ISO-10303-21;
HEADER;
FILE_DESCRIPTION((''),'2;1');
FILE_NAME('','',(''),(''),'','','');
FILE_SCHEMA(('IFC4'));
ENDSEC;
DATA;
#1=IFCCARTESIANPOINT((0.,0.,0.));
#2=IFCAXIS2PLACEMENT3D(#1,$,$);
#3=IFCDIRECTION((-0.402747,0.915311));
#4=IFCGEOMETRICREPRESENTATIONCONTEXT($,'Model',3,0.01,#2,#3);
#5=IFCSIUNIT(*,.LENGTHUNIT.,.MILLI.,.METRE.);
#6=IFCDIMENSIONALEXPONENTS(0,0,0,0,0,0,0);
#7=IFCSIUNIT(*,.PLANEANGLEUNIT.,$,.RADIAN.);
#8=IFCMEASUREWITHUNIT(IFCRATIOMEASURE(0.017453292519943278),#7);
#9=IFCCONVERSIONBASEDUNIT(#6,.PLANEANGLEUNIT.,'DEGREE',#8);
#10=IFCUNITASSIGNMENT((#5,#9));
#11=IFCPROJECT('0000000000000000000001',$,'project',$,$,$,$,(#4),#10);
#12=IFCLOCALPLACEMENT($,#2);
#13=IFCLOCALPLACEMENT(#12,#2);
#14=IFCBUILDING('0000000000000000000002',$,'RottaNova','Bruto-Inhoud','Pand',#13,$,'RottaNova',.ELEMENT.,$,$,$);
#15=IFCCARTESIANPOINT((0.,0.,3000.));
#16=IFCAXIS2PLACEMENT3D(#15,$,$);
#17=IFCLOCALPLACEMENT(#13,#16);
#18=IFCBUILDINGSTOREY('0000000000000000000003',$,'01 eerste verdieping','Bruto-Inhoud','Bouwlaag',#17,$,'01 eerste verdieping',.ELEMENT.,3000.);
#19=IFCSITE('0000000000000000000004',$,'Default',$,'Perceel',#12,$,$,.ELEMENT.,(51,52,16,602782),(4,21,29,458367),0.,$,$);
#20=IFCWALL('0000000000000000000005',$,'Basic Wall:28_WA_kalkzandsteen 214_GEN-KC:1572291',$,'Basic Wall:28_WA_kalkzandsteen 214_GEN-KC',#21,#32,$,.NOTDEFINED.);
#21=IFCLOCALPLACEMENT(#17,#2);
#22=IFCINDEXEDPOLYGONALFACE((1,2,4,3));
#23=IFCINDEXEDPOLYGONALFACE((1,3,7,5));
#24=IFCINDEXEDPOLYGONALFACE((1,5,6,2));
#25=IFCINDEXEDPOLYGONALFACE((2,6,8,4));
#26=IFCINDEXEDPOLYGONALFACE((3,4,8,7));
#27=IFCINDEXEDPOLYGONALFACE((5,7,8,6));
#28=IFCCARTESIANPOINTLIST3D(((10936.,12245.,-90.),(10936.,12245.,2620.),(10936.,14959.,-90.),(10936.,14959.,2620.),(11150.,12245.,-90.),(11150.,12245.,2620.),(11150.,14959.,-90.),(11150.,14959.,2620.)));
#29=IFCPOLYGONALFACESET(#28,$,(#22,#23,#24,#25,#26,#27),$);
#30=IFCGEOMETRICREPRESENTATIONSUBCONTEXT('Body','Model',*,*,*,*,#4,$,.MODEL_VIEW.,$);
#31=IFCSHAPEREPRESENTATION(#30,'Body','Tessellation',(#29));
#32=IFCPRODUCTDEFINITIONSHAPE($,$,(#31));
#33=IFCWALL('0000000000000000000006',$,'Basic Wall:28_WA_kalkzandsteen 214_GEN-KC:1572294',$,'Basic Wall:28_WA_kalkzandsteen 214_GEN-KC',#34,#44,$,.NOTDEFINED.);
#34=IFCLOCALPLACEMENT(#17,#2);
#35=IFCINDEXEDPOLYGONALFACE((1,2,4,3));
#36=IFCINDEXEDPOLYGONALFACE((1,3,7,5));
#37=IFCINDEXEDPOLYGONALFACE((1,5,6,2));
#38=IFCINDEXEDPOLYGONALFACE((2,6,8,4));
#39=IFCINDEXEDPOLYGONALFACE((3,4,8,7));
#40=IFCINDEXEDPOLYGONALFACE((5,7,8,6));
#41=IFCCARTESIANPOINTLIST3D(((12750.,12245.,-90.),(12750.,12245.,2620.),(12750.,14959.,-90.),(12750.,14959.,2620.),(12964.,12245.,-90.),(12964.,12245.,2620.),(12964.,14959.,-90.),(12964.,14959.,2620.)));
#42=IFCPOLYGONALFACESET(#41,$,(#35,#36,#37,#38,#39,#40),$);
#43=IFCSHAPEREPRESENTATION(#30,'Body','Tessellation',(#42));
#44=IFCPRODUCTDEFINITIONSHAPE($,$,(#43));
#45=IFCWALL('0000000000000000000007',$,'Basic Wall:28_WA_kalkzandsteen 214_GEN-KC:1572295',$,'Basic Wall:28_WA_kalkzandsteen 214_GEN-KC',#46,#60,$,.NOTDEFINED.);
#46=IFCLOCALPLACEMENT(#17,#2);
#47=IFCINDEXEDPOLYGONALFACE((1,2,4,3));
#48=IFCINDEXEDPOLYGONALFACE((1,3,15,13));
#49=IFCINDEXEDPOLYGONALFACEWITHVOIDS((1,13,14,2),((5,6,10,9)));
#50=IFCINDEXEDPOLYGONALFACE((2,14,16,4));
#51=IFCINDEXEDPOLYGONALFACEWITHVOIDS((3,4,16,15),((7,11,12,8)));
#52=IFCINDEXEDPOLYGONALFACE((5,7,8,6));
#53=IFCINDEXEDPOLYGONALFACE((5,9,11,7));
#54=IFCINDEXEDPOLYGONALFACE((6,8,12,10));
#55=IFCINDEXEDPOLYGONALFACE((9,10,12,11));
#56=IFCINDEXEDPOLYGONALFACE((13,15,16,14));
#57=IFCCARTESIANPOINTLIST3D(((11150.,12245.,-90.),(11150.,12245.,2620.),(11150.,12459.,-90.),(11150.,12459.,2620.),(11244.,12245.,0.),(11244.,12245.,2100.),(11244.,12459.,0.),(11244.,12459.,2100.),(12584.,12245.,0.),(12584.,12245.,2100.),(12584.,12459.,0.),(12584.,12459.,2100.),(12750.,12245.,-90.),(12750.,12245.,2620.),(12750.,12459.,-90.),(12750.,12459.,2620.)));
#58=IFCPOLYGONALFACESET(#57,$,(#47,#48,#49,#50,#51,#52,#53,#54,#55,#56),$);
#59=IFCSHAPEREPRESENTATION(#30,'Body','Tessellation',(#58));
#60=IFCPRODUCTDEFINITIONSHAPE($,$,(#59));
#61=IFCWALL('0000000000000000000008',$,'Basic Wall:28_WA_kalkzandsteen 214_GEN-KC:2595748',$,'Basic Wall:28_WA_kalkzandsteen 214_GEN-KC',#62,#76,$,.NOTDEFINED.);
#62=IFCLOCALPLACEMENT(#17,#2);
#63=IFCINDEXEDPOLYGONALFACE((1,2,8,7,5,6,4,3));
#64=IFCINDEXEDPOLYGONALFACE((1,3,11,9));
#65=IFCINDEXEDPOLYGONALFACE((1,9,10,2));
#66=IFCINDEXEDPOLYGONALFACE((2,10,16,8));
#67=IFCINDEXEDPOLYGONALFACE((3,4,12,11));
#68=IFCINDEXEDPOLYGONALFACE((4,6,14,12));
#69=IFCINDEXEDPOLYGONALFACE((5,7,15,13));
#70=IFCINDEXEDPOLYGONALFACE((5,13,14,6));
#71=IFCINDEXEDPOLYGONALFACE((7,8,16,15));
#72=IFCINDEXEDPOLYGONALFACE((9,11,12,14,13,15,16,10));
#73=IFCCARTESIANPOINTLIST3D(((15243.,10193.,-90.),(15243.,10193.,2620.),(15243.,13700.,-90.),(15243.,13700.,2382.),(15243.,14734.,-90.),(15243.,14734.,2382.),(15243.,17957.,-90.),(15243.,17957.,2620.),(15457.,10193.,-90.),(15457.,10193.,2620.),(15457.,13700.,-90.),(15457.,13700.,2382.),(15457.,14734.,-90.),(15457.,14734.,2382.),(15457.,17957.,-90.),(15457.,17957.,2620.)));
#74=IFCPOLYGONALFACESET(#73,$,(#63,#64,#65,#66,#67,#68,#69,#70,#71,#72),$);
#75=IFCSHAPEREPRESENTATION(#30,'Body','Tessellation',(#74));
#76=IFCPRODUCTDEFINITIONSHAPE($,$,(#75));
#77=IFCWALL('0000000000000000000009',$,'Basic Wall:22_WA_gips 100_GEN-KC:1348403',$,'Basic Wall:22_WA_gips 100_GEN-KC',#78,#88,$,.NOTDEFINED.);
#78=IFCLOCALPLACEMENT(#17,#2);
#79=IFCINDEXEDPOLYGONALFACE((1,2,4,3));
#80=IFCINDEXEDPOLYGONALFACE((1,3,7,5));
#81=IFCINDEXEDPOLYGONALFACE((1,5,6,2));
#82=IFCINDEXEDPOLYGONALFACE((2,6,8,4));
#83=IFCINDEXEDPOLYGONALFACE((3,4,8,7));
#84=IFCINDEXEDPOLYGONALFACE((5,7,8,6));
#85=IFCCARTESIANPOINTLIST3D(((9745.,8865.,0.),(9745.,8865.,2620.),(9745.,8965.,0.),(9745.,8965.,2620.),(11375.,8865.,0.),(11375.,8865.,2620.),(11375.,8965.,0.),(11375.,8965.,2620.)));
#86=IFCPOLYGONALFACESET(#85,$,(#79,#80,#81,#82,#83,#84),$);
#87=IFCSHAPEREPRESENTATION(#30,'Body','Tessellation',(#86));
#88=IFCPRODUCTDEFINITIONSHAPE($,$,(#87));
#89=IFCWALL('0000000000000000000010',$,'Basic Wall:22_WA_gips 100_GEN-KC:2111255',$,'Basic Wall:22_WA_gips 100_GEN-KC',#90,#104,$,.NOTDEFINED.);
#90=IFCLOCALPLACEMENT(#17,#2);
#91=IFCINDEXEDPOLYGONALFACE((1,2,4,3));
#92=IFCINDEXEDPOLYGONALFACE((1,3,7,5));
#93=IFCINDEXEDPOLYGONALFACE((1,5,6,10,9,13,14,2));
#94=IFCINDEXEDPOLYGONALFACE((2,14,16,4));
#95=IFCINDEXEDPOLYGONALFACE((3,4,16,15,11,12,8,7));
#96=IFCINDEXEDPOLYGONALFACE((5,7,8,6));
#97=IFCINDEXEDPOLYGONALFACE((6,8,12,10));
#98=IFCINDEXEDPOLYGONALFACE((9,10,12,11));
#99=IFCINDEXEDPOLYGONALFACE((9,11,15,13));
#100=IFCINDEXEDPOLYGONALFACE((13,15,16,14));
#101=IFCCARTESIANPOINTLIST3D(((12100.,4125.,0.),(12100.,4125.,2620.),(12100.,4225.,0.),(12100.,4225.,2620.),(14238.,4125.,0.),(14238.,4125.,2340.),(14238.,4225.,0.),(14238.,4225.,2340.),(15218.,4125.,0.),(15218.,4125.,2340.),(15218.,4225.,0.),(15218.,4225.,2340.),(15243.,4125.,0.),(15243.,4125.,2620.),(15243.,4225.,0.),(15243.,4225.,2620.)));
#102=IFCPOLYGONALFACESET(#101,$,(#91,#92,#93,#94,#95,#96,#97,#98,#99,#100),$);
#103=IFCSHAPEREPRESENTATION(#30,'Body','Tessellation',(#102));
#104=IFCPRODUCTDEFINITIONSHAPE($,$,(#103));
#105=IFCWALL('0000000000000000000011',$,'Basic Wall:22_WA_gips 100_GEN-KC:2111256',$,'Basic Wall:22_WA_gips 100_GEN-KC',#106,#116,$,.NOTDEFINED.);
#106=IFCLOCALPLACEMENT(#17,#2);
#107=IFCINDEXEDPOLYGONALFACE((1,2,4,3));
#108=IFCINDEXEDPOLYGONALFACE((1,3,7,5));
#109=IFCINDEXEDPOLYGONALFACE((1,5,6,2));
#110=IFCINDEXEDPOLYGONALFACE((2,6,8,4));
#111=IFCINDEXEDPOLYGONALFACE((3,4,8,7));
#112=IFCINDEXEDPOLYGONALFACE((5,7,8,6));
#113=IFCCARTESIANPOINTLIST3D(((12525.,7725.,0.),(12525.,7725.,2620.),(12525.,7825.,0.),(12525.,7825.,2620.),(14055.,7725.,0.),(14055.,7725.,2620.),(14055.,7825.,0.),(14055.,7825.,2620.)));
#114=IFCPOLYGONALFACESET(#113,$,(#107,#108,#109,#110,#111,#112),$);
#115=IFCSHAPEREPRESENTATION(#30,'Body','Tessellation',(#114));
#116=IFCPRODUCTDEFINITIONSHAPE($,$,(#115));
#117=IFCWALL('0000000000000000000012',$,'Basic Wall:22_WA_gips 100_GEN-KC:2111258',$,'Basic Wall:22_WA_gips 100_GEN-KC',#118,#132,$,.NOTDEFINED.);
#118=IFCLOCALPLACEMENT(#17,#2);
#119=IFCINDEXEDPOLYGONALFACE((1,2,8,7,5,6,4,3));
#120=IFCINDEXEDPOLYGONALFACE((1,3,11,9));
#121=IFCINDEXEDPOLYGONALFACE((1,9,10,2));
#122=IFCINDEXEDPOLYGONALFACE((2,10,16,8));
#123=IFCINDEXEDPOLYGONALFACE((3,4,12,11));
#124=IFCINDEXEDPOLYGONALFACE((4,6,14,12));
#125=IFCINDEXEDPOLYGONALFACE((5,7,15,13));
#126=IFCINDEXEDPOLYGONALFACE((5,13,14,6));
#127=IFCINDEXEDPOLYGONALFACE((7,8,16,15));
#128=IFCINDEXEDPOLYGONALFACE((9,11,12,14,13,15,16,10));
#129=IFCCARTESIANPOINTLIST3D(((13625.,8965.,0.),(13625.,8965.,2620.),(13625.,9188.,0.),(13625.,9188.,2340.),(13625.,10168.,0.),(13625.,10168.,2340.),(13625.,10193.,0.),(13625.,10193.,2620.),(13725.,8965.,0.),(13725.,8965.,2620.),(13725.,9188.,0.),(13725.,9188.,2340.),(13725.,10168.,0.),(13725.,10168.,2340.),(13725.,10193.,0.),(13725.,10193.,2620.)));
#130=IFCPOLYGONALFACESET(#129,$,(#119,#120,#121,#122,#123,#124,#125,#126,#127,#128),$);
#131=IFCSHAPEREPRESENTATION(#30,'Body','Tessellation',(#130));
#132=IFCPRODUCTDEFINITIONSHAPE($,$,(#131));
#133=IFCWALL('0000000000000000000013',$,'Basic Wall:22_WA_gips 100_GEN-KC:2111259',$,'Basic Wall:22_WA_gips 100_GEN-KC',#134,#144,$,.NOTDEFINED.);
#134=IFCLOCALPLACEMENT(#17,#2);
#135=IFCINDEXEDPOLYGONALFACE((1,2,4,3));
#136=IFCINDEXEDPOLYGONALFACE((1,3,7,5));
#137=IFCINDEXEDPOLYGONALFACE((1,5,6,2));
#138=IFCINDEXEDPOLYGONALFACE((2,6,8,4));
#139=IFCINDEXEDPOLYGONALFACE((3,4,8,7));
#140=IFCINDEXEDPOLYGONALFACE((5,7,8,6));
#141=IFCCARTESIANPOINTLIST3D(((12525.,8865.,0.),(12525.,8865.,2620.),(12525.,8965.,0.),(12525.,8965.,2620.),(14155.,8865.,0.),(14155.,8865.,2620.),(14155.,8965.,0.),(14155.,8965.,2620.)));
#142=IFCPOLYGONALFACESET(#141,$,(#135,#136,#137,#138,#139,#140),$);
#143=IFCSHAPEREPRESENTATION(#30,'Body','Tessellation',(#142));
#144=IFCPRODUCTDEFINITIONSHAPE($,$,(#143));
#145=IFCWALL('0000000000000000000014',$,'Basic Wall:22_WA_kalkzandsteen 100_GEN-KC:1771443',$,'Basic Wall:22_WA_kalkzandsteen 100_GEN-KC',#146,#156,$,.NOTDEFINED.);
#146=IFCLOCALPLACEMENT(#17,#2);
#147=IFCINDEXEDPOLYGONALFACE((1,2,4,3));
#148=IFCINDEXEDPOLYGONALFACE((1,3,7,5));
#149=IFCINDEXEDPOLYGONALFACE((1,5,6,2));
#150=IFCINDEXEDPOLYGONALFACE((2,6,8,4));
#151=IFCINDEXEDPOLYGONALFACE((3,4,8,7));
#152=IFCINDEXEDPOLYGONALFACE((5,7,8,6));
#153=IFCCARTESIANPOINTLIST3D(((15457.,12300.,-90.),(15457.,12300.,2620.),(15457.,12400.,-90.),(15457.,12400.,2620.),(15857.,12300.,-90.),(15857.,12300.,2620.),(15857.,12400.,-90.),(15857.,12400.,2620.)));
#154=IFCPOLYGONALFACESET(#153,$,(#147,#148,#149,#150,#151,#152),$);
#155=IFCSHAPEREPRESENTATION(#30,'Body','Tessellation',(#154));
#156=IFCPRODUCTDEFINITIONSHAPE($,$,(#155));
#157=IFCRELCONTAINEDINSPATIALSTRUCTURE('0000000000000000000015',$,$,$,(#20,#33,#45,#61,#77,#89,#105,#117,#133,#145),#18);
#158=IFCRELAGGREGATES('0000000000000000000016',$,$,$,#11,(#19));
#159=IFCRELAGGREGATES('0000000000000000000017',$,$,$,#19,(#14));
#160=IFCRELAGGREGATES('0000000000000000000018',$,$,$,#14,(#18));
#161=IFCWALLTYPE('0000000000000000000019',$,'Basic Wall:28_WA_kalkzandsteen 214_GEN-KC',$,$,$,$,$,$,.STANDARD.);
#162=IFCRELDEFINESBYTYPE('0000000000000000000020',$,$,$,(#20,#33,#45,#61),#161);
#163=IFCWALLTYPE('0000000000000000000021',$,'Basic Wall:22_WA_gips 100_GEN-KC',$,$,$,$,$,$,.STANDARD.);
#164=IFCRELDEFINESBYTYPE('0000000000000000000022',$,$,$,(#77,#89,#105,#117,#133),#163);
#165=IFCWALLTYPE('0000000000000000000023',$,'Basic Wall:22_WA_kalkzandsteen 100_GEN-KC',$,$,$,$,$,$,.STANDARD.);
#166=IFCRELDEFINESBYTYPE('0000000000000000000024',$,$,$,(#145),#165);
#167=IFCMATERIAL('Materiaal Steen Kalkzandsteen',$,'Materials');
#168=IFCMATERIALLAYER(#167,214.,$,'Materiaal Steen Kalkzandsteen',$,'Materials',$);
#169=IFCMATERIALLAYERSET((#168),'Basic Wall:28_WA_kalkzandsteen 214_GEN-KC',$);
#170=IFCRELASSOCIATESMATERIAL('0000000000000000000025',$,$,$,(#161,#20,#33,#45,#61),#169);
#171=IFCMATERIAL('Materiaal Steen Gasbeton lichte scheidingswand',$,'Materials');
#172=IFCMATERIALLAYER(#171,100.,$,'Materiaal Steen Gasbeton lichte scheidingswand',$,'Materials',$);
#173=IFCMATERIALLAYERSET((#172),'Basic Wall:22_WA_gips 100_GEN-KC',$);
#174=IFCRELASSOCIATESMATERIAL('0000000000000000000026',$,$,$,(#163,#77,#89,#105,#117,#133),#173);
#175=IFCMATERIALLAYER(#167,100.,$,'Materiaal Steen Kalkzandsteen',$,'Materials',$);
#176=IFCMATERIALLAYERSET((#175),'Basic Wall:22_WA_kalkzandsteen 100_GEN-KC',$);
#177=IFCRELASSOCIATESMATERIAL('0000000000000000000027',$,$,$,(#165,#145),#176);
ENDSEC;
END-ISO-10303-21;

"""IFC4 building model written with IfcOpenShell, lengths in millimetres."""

from ifc_helpers import new_model, entity, si_unit, converted_unit, direction, frame, frame_2d, origin, place, context, subcontext, project, spatial, rectangle, extrude, material, layer, layer_set, type_object, element, save


model = new_model("IFC4")

# Units and contexts
model_context = context("Model", 3, precision=0.01, world=origin(), true_north=direction((-0.402747, 0.915311)))
body_context = subcontext(model_context, "Body", "Model", "MODEL_VIEW")
ifc_project = project(units=[si_unit("LENGTHUNIT", "METRE", prefix="MILLI"), converted_unit("PLANEANGLEUNIT", "DEGREE", entity("IfcRatioMeasure", 0.017453292519943278), si_unit("PLANEANGLEUNIT", "RADIAN"), dimensions=[0, 0, 0, 0, 0, 0, 0])], contexts=[model_context])

# Site, building, storey
site_placement = place(None, origin())
site = spatial("IfcSite", under=ifc_project, at=site_placement, Name="Default", ObjectType="Perceel", CompositionType="ELEMENT", RefLatitude=(51, 52, 16, 602782), RefLongitude=(4, 21, 29, 458367), RefElevation=0.0)
building_placement = place(site_placement, origin())
building = spatial("IfcBuilding", under=site, at=building_placement, Name="RottaNova", Description="Bruto-Inhoud", ObjectType="Pand", LongName="RottaNova", CompositionType="ELEMENT")
storey_placement = place(building_placement, frame((0.0, 0.0, 3000.0)))
storey = spatial("IfcBuildingStorey", under=building, at=storey_placement, Name="01 eerste verdieping", Description="Bruto-Inhoud", ObjectType="Bouwlaag", LongName="01 eerste verdieping", CompositionType="ELEMENT", Elevation=3000.0)

# Walls
ifc_material_1 = material(Name="Materiaal Steen Kalkzandsteen", Category="Materials")
ifc_layer_1 = layer(ifc_material_1, 214.0, Name="Materiaal Steen Kalkzandsteen", Category="Materials")
ifc_layer_set_1 = layer_set([ifc_layer_1], Name="Basic Wall:28_WA_kalkzandsteen 214_GEN-KC")
wall_type_1 = type_object("IfcWallType", Name="Basic Wall:28_WA_kalkzandsteen 214_GEN-KC", PredefinedType="STANDARD", material=ifc_layer_set_1)
wall_1_placement = place(storey_placement, frame((11043.0, 12245.0, -90.0), z_axis=(0.0, 0.0, 1.0), x_axis=(0.0, 1.0, 0.0)))
element("IfcWall", 1, at=wall_1_placement, inside=storey, type_object=wall_type_1, material=ifc_layer_set_1, Name="Basic Wall:28_WA_kalkzandsteen 214_GEN-KC:1572291", ObjectType="Basic Wall:28_WA_kalkzandsteen 214_GEN-KC", PredefinedType="NOTDEFINED", context=body_context, shape_type="SweptSolid", body=[
    extrude(rectangle(XDim=2714.0, YDim=214.0, at=frame_2d((1357.0, 0.0), x_axis=(-1.0, 0.0))), origin(), (0.0, 0.0, 1.0), 2710.0),
])
wall_2_placement = place(storey_placement, frame((12857.0, 12245.0, -90.0), z_axis=(0.0, 0.0, 1.0), x_axis=(0.0, 1.0, 0.0)))
element("IfcWall", 2, at=wall_2_placement, inside=storey, type_object=wall_type_1, material=ifc_layer_set_1, Name="Basic Wall:28_WA_kalkzandsteen 214_GEN-KC:1572294", ObjectType="Basic Wall:28_WA_kalkzandsteen 214_GEN-KC", PredefinedType="NOTDEFINED", context=body_context, shape_type="SweptSolid", body=[
    extrude(rectangle(XDim=2714.0, YDim=214.0, at=frame_2d((1357.0, 0.0), x_axis=(-1.0, 0.0))), origin(), (0.0, 0.0, 1.0), 2710.0),
])

# Walls, openings
wall_3_placement = place(storey_placement, frame((11150.0, 12352.0, -90.0)))
wall_3 = element("IfcWall", 3, at=wall_3_placement, inside=storey, type_object=wall_type_1, material=ifc_layer_set_1, Name="Basic Wall:28_WA_kalkzandsteen 214_GEN-KC:1572295", ObjectType="Basic Wall:28_WA_kalkzandsteen 214_GEN-KC", PredefinedType="NOTDEFINED", context=body_context, shape_type="SweptSolid", body=[
    extrude(rectangle(XDim=1600.0, YDim=214.0, at=frame_2d((800.0, 0.0), x_axis=(-1.0, 0.0))), origin(), (0.0, 0.0, 1.0), 2710.0),
])
opening_1_placement = place(wall_3_placement, frame((94.0, -1631.0, 90.0)))
element("IfcOpeningElement", 4, at=opening_1_placement, cuts=wall_3, PredefinedType="OPENING", context=body_context, shape_type="SweptSolid", body=[
    extrude(rectangle(XDim=2100.0, YDim=1340.0, at=frame_2d((0.0, 0.0), x_axis=(1.0, 0.0))), frame((670.0, 0.0, 1050.0), z_axis=(0.0, 1.0, 0.0), x_axis=(0.0, 0.0, -1.0)), (0.0, 0.0, 1.0), 3048.0),
])
wall_4_placement = place(storey_placement, frame((15350.0, 10193.0, -90.0), z_axis=(0.0, 0.0, 1.0), x_axis=(0.0, 1.0, 0.0)))
wall_4 = element("IfcWall", 5, at=wall_4_placement, inside=storey, type_object=wall_type_1, material=ifc_layer_set_1, Name="Basic Wall:28_WA_kalkzandsteen 214_GEN-KC:2595748", ObjectType="Basic Wall:28_WA_kalkzandsteen 214_GEN-KC", PredefinedType="NOTDEFINED", context=body_context, shape_type="SweptSolid", body=[
    extrude(rectangle(XDim=7764.0, YDim=214.0, at=frame_2d((3882.0, 0.0), x_axis=(1.0, 0.0))), origin(), (0.0, 0.0, 1.0), 2710.0),
])
opening_2_placement = place(wall_4_placement, frame((3507.0, 107.0, 0.0)))
element("IfcOpeningElement", 6, at=opening_2_placement, cuts=wall_4, PredefinedType="OPENING", context=body_context, shape_type="SweptSolid", body=[
    extrude(rectangle(XDim=2472.0, YDim=1034.0, at=frame_2d((0.0, 0.0), x_axis=(1.0, 0.0))), frame((517.0, -214.0, 1236.0), z_axis=(0.0, 1.0, 0.0), x_axis=(0.0, 0.0, -1.0)), (0.0, 0.0, 1.0), 214.0),
])

# Wall
ifc_material_2 = material(Name="Materiaal Steen Gasbeton lichte scheidingswand", Category="Materials")
ifc_layer_2 = layer(ifc_material_2, 100.0, Name="Materiaal Steen Gasbeton lichte scheidingswand", Category="Materials")
ifc_layer_set_2 = layer_set([ifc_layer_2], Name="Basic Wall:22_WA_gips 100_GEN-KC")
wall_type_2 = type_object("IfcWallType", Name="Basic Wall:22_WA_gips 100_GEN-KC", PredefinedType="STANDARD", material=ifc_layer_set_2)
wall_5_placement = place(storey_placement, frame((11375.0, 8915.0, 0.0), z_axis=(0.0, 0.0, 1.0), x_axis=(-1.0, 0.0, 0.0)))
element("IfcWall", 7, at=wall_5_placement, inside=storey, type_object=wall_type_2, material=ifc_layer_set_2, Name="Basic Wall:22_WA_gips 100_GEN-KC:1348403", ObjectType="Basic Wall:22_WA_gips 100_GEN-KC", PredefinedType="NOTDEFINED", context=body_context, shape_type="SweptSolid", body=[
    extrude(rectangle(XDim=1630.0, YDim=100.0, at=frame_2d((815.0, 0.0), x_axis=(-1.0, 0.0))), origin(), (0.0, 0.0, 1.0), 2620.0),
])

# Wall, opening
wall_6_placement = place(storey_placement, frame((15243.0, 4175.0, 0.0), z_axis=(0.0, 0.0, 1.0), x_axis=(-1.0, 0.0, 0.0)))
wall_6 = element("IfcWall", 8, at=wall_6_placement, inside=storey, type_object=wall_type_2, material=ifc_layer_set_2, Name="Basic Wall:22_WA_gips 100_GEN-KC:2111255", ObjectType="Basic Wall:22_WA_gips 100_GEN-KC", PredefinedType="NOTDEFINED", context=body_context, shape_type="SweptSolid", body=[
    extrude(rectangle(XDim=3143.0, YDim=100.0, at=frame_2d((1571.5, 0.0), x_axis=(-1.0, 0.0))), origin(), (0.0, 0.0, 1.0), 2620.0),
])
opening_3_placement = place(wall_6_placement, frame((25.0, -50.0, -90.0)))
element("IfcOpeningElement", 9, at=opening_3_placement, cuts=wall_6, PredefinedType="OPENING", context=body_context, shape_type="SweptSolid", body=[
    extrude(rectangle(XDim=2430.0, YDim=980.0, at=frame_2d((1215.0, 490.0), x_axis=(1.0, 0.0))), frame((0.0, 0.0, 0.0), z_axis=(0.0, 1.0, 0.0), x_axis=(0.0, 0.0, 1.0)), (0.0, 0.0, 1.0), 100.0),
])

# Wall
wall_7_placement = place(storey_placement, frame((14055.0, 7775.0, 0.0), z_axis=(0.0, 0.0, 1.0), x_axis=(-1.0, 0.0, 0.0)))
element("IfcWall", 10, at=wall_7_placement, inside=storey, type_object=wall_type_2, material=ifc_layer_set_2, Name="Basic Wall:22_WA_gips 100_GEN-KC:2111256", ObjectType="Basic Wall:22_WA_gips 100_GEN-KC", PredefinedType="NOTDEFINED", context=body_context, shape_type="SweptSolid", body=[
    extrude(rectangle(XDim=1530.0, YDim=100.0, at=frame_2d((765.0, 0.0), x_axis=(-1.0, 0.0))), origin(), (0.0, 0.0, 1.0), 2620.0),
])

# Wall, opening
wall_8_placement = place(storey_placement, frame((13675.0, 8965.0, 0.0), z_axis=(0.0, 0.0, 1.0), x_axis=(0.0, 1.0, 0.0)))
wall_8 = element("IfcWall", 11, at=wall_8_placement, inside=storey, type_object=wall_type_2, material=ifc_layer_set_2, Name="Basic Wall:22_WA_gips 100_GEN-KC:2111258", ObjectType="Basic Wall:22_WA_gips 100_GEN-KC", PredefinedType="NOTDEFINED", context=body_context, shape_type="SweptSolid", body=[
    extrude(rectangle(XDim=1228.0, YDim=100.0, at=frame_2d((614.0, 0.0), x_axis=(1.0, 0.0))), origin(), (0.0, 0.0, 1.0), 2620.0),
])
opening_4_placement = place(wall_8_placement, frame((1203.0, 50.0, -90.0)))
element("IfcOpeningElement", 12, at=opening_4_placement, cuts=wall_8, PredefinedType="OPENING", context=body_context, shape_type="SweptSolid", body=[
    extrude(rectangle(XDim=2430.0, YDim=980.0, at=frame_2d((1215.0, 490.0), x_axis=(1.0, 0.0))), frame((0.0, 0.0, 0.0), z_axis=(0.0, -1.0, 0.0), x_axis=(0.0, 0.0, 1.0)), (0.0, 0.0, 1.0), 100.0),
])

# Walls
wall_9_placement = place(storey_placement, frame((12525.0, 8915.0, 0.0)))
element("IfcWall", 13, at=wall_9_placement, inside=storey, type_object=wall_type_2, material=ifc_layer_set_2, Name="Basic Wall:22_WA_gips 100_GEN-KC:2111259", ObjectType="Basic Wall:22_WA_gips 100_GEN-KC", PredefinedType="NOTDEFINED", context=body_context, shape_type="SweptSolid", body=[
    extrude(rectangle(XDim=1630.0, YDim=100.0, at=frame_2d((815.0, 0.0), x_axis=(-1.0, 0.0))), origin(), (0.0, 0.0, 1.0), 2620.0),
])
ifc_layer_3 = layer(ifc_material_1, 100.0, Name="Materiaal Steen Kalkzandsteen", Category="Materials")
ifc_layer_set_3 = layer_set([ifc_layer_3], Name="Basic Wall:22_WA_kalkzandsteen 100_GEN-KC")
wall_type_3 = type_object("IfcWallType", Name="Basic Wall:22_WA_kalkzandsteen 100_GEN-KC", PredefinedType="STANDARD", material=ifc_layer_set_3)
wall_10_placement = place(storey_placement, frame((15857.0, 12350.0, -90.0), z_axis=(0.0, 0.0, 1.0), x_axis=(-1.0, 0.0, 0.0)))
element("IfcWall", 14, at=wall_10_placement, inside=storey, type_object=wall_type_3, material=ifc_layer_set_3, Name="Basic Wall:22_WA_kalkzandsteen 100_GEN-KC:1771443", ObjectType="Basic Wall:22_WA_kalkzandsteen 100_GEN-KC", PredefinedType="NOTDEFINED", context=body_context, shape_type="SweptSolid", body=[
    extrude(rectangle(XDim=400.0, YDim=100.0, at=frame_2d((200.0, 0.0), x_axis=(-1.0, 0.0))), origin(), (0.0, 0.0, 1.0), 2710.0),
])

save(model, "model.ifc")
